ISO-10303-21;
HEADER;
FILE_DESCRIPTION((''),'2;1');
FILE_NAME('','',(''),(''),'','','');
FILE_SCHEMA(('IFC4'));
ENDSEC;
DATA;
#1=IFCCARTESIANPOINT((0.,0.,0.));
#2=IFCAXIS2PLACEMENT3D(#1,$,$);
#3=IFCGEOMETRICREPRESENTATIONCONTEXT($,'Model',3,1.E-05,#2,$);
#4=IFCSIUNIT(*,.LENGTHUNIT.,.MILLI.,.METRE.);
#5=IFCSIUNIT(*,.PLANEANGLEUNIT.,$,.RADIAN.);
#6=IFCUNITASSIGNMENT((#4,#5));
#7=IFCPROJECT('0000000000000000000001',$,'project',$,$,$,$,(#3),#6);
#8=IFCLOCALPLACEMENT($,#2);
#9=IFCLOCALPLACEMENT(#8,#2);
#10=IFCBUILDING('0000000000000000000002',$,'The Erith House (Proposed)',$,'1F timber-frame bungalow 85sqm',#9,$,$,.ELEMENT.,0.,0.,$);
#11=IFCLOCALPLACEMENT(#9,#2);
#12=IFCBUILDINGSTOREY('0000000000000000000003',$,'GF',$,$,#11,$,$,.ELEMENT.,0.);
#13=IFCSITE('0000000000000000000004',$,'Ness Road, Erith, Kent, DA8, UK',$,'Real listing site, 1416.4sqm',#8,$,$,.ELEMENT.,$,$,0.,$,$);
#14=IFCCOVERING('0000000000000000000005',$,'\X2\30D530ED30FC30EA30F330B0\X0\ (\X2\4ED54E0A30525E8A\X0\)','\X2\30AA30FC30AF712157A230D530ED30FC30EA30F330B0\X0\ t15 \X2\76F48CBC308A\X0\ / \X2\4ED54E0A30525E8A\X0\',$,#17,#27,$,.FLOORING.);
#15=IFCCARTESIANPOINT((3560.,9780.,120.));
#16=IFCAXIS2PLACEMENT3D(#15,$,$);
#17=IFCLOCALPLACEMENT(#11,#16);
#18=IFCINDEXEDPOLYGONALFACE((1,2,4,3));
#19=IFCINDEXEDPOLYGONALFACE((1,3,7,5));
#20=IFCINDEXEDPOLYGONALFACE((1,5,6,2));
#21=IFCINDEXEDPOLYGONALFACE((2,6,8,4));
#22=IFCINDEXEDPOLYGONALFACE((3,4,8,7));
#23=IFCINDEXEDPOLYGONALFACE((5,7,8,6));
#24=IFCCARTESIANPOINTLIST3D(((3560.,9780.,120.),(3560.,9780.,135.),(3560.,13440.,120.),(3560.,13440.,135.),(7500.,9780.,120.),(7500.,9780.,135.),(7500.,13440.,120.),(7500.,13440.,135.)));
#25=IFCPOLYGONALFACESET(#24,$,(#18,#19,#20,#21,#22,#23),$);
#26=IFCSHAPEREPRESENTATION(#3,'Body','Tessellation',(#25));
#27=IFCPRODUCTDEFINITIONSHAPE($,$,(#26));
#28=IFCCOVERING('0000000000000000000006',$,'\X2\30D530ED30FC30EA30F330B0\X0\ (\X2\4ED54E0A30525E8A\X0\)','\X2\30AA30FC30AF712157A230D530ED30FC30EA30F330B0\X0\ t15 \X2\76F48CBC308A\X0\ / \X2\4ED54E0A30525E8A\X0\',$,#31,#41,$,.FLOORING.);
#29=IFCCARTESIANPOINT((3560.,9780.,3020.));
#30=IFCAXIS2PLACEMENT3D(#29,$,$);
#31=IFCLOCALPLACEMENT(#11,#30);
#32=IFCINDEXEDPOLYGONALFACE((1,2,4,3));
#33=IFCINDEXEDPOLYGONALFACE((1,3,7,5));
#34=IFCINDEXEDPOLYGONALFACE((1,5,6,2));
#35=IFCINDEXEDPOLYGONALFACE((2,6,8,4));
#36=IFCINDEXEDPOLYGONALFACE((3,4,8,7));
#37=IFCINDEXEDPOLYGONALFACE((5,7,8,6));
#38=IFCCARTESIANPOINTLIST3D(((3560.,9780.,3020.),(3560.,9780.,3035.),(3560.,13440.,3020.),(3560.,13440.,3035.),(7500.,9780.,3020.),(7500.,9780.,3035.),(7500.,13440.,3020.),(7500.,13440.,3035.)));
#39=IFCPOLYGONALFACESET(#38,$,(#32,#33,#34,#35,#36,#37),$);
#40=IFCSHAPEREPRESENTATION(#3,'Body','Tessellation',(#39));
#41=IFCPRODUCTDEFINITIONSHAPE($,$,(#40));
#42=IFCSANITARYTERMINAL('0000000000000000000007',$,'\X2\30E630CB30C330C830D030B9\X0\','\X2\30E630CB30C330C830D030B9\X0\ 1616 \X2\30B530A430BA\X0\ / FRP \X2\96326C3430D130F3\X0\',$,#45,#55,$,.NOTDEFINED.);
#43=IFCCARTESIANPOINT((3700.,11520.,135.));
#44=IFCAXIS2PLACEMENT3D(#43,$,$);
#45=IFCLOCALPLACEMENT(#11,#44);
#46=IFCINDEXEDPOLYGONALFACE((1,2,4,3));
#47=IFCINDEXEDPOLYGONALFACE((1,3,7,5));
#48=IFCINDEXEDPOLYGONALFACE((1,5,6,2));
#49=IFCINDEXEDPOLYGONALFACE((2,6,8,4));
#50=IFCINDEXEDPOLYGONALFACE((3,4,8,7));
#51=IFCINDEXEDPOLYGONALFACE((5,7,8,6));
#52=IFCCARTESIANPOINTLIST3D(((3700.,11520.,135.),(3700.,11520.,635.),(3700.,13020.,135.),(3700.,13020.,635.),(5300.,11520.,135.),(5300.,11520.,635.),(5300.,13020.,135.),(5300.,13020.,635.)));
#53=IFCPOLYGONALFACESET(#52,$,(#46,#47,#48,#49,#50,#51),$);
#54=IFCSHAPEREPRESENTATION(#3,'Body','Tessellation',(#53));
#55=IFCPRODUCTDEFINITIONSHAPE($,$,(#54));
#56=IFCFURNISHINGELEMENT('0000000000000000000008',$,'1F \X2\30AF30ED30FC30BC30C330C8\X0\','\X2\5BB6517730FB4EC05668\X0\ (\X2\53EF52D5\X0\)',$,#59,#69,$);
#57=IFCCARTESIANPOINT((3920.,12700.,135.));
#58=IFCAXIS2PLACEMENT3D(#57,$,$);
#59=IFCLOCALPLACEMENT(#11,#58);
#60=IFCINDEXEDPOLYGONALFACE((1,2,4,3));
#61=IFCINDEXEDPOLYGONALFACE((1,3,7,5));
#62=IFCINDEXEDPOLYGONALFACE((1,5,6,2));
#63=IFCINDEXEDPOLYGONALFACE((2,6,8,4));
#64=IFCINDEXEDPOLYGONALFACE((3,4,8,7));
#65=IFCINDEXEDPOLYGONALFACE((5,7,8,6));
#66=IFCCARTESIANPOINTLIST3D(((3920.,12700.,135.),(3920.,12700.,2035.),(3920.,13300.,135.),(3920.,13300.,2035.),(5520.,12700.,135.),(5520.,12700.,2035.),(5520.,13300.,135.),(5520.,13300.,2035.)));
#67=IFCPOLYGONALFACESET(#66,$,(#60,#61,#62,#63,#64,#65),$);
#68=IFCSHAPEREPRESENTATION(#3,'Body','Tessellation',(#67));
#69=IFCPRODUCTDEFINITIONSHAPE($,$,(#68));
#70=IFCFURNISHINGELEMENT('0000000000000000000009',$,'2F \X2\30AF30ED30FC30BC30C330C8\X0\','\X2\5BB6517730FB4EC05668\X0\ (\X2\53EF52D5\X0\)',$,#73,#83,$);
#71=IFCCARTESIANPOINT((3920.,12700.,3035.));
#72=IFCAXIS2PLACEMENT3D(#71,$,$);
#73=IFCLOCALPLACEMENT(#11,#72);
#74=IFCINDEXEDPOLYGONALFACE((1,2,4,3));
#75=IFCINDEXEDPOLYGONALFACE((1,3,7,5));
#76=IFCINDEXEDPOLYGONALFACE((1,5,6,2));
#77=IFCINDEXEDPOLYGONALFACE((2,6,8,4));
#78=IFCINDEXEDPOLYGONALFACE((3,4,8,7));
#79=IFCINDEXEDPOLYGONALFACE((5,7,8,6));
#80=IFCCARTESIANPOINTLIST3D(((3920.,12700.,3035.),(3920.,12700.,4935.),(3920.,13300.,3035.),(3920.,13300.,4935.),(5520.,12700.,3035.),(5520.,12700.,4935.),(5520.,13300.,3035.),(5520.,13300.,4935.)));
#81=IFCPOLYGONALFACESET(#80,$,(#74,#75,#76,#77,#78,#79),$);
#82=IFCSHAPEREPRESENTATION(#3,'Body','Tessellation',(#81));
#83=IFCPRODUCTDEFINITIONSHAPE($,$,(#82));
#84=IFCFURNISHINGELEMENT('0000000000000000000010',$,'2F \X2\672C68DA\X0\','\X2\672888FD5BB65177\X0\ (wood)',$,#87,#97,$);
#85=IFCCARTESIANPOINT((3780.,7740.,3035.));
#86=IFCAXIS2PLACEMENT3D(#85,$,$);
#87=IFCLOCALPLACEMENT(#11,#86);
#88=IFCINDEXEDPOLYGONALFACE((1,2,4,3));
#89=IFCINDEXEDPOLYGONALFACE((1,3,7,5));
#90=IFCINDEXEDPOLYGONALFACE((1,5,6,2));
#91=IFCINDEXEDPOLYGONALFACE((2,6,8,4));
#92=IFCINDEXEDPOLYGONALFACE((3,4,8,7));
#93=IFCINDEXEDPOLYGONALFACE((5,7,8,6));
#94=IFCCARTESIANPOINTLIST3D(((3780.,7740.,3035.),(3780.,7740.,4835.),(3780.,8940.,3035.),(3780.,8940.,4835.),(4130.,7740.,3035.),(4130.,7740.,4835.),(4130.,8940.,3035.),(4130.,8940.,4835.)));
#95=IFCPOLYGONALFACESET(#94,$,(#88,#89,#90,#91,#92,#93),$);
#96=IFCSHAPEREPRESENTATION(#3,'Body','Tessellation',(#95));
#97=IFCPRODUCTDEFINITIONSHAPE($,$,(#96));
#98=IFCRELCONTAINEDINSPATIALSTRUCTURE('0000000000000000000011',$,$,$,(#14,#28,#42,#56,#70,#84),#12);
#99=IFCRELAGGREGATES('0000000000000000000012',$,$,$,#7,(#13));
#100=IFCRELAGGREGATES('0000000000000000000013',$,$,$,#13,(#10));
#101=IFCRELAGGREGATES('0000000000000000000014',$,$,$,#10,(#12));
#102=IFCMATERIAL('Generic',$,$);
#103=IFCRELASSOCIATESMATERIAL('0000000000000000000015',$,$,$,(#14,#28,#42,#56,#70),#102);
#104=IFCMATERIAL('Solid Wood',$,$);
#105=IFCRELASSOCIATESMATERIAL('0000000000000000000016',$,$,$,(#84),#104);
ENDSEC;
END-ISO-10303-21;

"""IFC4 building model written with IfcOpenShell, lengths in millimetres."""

from ifc_helpers import new_model, si_unit, frame, frame_2d, origin, place, context, project, spatial, rectangle, extrude, material, element, save


model = new_model("IFC4")

# Units and contexts
model_context = context("Model", 3, precision=1e-05, world=origin())
ifc_project = project(units=[si_unit("LENGTHUNIT", "METRE", prefix="MILLI"), si_unit("PLANEANGLEUNIT", "RADIAN")], contexts=[model_context])

# Site, building, storey
site_placement = place(None, origin())
site = spatial("IfcSite", under=ifc_project, at=site_placement, Name="Ness Road, Erith, Kent, DA8, UK", ObjectType="Real listing site, 1416.4sqm", CompositionType="ELEMENT", RefElevation=0.0)
building_placement = place(site_placement, origin())
building = spatial("IfcBuilding", under=site, at=building_placement, Name="The Erith House (Proposed)", ObjectType="1F timber-frame bungalow 85sqm", CompositionType="ELEMENT", ElevationOfRefHeight=0.0, ElevationOfTerrain=0.0)
storey_placement = place(building_placement, origin())
storey = spatial("IfcBuildingStorey", under=building, at=storey_placement, Name="GF", CompositionType="ELEMENT", Elevation=0.0)

# Shared definitions
ifc_material_1 = material(Name="Solid Wood")

# Coverings
ifc_material_2 = material(Name="Generic")
covering_1_placement = place(storey_placement, frame((3560.0, 9780.0, 120.0)))
element("IfcCovering", 1, at=covering_1_placement, inside=storey, material=ifc_material_2, Name="フローリング (仕上げ床)", Description="オーク無垢フローリング t15 直貼り / 仕上げ床", PredefinedType="FLOORING", context=model_context, shape_type="SweptSolid", body=[
    extrude(rectangle(XDim=3940.0, YDim=3660.0, at=frame_2d((1970.0, 1830.0))), frame((3560.0, 9780.0, 120.0)), (0.0, 0.0, 1.0), 15.0),
])
covering_2_placement = place(storey_placement, frame((3560.0, 9780.0, 3020.0)))
element("IfcCovering", 2, at=covering_2_placement, inside=storey, material=ifc_material_2, Name="フローリング (仕上げ床)", Description="オーク無垢フローリング t15 直貼り / 仕上げ床", PredefinedType="FLOORING", context=model_context, shape_type="SweptSolid", body=[
    extrude(rectangle(XDim=3940.0, YDim=3660.0, at=frame_2d((1970.0, 1830.0))), frame((3560.0, 9780.0, 3020.0)), (0.0, 0.0, 1.0), 15.0),
])

# Sanitary terminal
sanitary_terminal_placement = place(storey_placement, frame((3700.0, 11520.0, 135.0)))
element("IfcSanitaryTerminal", 3, at=sanitary_terminal_placement, inside=storey, material=ifc_material_2, Name="ユニットバス", Description="ユニットバス 1616 サイズ / FRP 防水パン", PredefinedType="NOTDEFINED", context=model_context, shape_type="SweptSolid", body=[
    extrude(rectangle(XDim=1600.0, YDim=1500.0, at=frame_2d((800.0, 750.0))), frame((3700.0, 11520.0, 135.0)), (0.0, 0.0, 1.0), 500.0),
])

# Furnishing elements
furnishing_1_placement = place(storey_placement, frame((3920.0, 12700.0, 135.0)))
element("IfcFurnishingElement", 4, at=furnishing_1_placement, inside=storey, material=ifc_material_2, Name="1F クローゼット", Description="家具・什器 (可動)", context=model_context, shape_type="SweptSolid", body=[
    extrude(rectangle(XDim=1600.0, YDim=600.0, at=frame_2d((800.0, 300.0))), frame((3920.0, 12700.0, 135.0)), (0.0, 0.0, 1.0), 1900.0),
])
furnishing_2_placement = place(storey_placement, frame((3920.0, 12700.0, 3035.0)))
element("IfcFurnishingElement", 5, at=furnishing_2_placement, inside=storey, material=ifc_material_2, Name="2F クローゼット", Description="家具・什器 (可動)", context=model_context, shape_type="SweptSolid", body=[
    extrude(rectangle(XDim=1600.0, YDim=600.0, at=frame_2d((800.0, 300.0))), frame((3920.0, 12700.0, 3035.0)), (0.0, 0.0, 1.0), 1900.0),
])
furnishing_3_placement = place(storey_placement, frame((3780.0, 7740.0, 3035.0)))
element("IfcFurnishingElement", 6, at=furnishing_3_placement, inside=storey, material=ifc_material_1, Name="2F 本棚", Description="木製家具 (wood)", context=model_context, shape_type="SweptSolid", body=[
    extrude(rectangle(XDim=350.0, YDim=1200.0, at=frame_2d((175.0, 600.0))), frame((3780.0, 7740.0, 3035.0)), (0.0, 0.0, 1.0), 1800.0),
])

save(model, "model.ifc")
